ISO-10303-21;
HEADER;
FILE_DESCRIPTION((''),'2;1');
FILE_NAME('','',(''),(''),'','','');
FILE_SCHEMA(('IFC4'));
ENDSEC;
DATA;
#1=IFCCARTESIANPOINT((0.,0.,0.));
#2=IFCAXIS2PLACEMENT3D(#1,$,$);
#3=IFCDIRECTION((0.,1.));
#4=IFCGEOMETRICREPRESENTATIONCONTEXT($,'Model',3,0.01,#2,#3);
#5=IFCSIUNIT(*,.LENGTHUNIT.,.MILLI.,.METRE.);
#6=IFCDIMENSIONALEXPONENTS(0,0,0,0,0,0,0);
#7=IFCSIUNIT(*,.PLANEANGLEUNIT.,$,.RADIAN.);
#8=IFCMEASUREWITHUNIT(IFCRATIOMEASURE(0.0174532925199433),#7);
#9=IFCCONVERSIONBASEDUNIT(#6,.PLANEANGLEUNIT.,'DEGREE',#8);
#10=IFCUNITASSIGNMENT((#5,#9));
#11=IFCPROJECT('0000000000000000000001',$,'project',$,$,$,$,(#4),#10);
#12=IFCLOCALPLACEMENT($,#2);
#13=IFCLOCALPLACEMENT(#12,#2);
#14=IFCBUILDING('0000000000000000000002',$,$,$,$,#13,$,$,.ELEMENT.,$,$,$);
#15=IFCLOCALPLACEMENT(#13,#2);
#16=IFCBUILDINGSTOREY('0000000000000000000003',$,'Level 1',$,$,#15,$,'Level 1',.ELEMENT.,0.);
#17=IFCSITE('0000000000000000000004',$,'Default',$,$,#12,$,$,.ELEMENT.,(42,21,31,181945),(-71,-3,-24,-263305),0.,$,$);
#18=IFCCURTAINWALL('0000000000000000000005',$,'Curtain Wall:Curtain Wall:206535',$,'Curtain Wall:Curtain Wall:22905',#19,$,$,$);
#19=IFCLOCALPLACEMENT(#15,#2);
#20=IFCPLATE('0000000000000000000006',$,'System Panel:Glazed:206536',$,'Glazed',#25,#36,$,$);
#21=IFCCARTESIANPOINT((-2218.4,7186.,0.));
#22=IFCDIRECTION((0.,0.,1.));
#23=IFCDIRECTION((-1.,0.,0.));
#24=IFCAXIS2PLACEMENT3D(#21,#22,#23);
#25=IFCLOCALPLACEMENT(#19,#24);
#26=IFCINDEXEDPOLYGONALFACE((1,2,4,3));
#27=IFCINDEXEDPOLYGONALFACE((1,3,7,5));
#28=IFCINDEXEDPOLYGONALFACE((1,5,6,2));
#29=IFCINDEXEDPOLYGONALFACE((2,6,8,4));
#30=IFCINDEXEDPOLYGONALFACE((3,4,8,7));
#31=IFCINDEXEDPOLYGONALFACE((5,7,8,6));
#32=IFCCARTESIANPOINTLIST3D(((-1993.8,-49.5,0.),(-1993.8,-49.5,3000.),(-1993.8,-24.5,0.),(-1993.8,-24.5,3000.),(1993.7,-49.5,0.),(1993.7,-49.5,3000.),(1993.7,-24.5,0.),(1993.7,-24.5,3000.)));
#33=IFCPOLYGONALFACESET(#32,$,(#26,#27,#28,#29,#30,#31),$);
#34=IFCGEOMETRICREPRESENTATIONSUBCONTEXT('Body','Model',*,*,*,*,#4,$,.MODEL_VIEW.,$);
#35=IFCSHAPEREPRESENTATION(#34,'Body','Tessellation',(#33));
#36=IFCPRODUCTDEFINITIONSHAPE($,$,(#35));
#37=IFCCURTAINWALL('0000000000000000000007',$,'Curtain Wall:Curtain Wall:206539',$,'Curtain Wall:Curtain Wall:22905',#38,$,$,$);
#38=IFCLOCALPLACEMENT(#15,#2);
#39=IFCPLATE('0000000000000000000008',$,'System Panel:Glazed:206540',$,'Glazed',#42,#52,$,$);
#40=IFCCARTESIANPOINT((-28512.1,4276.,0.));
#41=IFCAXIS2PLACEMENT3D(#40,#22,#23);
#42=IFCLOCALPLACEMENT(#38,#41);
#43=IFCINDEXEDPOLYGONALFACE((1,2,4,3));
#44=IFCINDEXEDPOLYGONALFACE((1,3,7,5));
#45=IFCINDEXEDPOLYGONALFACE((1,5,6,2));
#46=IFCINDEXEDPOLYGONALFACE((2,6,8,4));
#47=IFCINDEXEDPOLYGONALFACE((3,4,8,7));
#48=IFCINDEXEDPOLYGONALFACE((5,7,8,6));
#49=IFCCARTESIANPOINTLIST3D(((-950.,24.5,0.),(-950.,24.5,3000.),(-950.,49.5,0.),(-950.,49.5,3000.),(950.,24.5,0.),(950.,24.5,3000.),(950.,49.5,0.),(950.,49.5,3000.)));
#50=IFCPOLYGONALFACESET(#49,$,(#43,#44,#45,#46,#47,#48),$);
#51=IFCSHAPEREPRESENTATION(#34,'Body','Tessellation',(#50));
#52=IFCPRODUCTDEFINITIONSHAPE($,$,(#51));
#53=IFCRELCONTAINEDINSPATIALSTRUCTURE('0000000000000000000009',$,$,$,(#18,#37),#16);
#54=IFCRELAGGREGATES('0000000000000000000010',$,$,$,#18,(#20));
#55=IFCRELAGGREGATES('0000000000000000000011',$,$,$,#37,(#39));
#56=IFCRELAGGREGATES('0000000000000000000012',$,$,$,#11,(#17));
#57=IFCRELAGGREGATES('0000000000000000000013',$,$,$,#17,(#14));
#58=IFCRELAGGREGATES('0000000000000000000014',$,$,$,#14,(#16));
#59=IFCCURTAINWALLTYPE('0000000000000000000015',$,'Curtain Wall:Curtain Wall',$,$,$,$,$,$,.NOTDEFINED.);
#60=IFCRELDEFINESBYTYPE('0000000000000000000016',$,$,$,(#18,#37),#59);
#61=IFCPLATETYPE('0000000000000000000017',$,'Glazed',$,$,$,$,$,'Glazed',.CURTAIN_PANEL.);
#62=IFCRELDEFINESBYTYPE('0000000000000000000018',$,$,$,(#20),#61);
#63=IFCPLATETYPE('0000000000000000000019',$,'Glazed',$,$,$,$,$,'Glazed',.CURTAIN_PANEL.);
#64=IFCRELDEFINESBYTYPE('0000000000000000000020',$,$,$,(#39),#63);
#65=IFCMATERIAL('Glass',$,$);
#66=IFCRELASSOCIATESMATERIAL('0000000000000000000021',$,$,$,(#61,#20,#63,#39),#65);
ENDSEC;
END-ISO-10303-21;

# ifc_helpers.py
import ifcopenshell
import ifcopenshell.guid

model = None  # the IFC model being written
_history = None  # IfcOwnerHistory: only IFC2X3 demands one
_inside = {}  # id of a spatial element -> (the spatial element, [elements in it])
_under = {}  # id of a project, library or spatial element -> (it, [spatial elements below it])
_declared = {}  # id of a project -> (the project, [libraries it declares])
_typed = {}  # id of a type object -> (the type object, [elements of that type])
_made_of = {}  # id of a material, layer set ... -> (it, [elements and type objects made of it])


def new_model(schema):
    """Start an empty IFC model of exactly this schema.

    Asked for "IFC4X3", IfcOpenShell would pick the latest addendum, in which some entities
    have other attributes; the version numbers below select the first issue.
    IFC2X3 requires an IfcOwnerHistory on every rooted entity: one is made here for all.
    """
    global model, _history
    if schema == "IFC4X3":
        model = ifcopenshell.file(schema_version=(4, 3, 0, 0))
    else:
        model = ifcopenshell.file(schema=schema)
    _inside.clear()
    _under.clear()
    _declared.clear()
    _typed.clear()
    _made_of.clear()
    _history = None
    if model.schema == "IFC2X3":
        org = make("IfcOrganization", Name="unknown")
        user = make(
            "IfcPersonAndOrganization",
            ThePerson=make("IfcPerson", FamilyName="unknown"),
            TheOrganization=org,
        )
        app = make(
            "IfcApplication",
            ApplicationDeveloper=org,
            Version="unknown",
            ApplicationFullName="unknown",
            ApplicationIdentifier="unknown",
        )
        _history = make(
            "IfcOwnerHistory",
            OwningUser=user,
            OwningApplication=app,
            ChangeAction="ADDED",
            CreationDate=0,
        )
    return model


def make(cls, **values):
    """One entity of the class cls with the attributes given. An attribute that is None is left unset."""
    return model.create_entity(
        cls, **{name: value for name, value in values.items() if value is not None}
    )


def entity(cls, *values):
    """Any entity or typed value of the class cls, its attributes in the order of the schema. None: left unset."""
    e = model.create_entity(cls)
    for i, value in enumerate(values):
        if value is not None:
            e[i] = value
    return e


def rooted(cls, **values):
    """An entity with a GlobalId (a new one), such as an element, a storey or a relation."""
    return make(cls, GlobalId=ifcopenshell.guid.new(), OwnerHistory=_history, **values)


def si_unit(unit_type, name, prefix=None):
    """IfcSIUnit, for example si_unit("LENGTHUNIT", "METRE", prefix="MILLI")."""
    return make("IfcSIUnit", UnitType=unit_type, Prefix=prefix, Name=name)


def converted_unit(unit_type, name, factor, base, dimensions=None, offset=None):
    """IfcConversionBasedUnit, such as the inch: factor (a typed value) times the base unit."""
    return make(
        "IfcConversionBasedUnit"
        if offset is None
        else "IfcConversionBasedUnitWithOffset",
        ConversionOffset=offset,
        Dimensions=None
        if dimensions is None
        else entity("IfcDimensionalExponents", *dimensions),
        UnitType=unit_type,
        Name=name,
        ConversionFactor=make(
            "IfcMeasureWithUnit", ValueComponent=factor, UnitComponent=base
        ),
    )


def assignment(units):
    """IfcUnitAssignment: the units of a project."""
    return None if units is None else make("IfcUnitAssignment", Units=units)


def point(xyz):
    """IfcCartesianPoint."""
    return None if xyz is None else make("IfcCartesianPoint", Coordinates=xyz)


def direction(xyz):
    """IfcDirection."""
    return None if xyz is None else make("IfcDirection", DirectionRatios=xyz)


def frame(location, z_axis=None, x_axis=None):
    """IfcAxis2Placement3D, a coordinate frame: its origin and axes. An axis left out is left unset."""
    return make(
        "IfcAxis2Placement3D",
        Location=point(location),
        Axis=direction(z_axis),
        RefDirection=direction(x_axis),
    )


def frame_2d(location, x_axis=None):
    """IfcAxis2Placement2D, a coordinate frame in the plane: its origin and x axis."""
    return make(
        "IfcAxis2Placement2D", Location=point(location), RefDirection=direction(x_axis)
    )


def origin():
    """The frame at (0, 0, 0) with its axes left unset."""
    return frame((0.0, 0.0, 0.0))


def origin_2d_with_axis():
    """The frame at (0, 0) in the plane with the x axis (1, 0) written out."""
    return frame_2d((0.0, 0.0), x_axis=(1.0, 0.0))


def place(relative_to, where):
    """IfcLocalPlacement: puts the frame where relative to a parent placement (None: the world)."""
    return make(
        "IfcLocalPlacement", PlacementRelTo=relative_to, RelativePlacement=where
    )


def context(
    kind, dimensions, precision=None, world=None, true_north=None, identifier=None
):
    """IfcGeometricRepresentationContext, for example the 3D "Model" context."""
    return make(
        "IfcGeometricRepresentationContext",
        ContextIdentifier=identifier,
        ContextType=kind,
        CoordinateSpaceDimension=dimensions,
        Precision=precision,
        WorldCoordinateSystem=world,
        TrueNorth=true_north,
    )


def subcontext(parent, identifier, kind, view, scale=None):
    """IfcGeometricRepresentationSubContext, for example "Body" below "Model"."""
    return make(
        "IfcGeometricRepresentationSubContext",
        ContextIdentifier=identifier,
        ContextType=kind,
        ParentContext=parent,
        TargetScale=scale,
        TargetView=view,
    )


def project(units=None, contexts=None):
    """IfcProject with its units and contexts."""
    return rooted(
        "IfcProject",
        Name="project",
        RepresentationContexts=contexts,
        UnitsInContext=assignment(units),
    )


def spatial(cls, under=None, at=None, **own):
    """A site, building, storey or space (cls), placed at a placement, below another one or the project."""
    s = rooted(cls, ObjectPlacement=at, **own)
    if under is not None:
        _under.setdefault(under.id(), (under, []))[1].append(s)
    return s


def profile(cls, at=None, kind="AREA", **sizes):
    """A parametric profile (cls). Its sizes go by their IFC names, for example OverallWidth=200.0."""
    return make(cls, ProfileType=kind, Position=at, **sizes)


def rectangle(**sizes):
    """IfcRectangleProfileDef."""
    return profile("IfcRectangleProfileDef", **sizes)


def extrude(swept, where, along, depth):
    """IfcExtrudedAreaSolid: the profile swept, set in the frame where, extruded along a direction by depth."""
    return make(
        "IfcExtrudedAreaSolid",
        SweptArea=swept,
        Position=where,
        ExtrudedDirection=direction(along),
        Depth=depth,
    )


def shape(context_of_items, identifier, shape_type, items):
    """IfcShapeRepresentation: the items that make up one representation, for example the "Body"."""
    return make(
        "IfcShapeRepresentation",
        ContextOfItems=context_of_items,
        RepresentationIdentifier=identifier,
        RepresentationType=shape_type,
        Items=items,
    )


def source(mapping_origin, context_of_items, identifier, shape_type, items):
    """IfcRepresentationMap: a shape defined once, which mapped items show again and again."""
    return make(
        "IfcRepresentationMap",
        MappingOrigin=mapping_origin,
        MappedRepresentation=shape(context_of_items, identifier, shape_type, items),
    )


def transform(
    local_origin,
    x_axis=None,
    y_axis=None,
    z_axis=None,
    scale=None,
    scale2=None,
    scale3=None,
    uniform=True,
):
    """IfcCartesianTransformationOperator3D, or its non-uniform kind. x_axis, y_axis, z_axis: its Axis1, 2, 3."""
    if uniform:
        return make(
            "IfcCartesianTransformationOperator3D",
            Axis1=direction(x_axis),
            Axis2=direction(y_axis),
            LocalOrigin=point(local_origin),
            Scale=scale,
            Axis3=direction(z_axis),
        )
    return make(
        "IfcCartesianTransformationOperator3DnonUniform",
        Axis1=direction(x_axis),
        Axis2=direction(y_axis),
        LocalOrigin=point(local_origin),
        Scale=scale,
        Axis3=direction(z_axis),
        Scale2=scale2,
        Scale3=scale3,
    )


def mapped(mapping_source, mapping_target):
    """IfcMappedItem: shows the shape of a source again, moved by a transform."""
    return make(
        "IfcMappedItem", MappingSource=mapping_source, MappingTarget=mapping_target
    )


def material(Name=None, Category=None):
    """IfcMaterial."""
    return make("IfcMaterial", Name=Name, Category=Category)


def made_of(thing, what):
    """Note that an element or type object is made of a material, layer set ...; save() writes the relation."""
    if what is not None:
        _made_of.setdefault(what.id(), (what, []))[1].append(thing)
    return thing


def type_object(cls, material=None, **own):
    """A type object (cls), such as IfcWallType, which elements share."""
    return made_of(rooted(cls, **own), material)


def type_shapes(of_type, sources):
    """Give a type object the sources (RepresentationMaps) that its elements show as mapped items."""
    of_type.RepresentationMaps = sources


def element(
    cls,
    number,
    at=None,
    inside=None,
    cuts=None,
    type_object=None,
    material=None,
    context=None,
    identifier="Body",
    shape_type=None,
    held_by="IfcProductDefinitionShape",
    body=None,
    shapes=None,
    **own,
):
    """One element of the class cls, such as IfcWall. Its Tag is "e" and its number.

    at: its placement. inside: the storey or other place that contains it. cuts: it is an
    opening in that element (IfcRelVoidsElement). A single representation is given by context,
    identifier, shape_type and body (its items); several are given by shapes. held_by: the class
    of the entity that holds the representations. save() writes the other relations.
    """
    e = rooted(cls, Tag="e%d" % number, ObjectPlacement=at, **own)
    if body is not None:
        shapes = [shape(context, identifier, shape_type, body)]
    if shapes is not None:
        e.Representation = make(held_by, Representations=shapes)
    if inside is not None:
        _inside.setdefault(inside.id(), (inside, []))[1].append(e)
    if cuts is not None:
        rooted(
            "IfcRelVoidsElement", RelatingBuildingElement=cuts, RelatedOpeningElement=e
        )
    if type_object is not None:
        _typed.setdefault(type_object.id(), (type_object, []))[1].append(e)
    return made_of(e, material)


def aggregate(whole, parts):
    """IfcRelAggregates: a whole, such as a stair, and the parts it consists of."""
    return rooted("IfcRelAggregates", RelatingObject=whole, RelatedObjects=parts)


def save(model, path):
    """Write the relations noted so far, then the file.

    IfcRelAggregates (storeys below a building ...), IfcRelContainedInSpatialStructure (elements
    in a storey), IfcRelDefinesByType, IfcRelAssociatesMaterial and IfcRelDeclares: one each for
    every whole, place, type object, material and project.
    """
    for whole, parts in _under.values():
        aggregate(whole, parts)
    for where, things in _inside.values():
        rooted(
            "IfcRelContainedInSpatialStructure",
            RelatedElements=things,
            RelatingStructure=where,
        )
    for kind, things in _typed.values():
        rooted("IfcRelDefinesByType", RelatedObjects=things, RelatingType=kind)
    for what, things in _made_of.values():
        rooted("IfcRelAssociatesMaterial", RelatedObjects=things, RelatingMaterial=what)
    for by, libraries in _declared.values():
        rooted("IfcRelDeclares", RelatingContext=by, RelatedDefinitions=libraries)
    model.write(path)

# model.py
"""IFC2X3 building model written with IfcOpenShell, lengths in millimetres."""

from ifc_helpers import new_model, entity, si_unit, converted_unit, direction, frame, frame_2d, origin, origin_2d_with_axis, place, context, subcontext, project, spatial, rectangle, extrude, source, transform, mapped, material, type_object, type_shapes, element, aggregate, save


model = new_model("IFC2X3")

# Units and contexts
model_context = context("Model", 3, precision=0.01, world=origin(), true_north=direction((0.0, 1.0)))
body_context = subcontext(model_context, "Body", "Model", "MODEL_VIEW")
ifc_project = project(units=[si_unit("LENGTHUNIT", "METRE", prefix="MILLI"), converted_unit("PLANEANGLEUNIT", "DEGREE", entity("IfcRatioMeasure", 0.0174532925199433), si_unit("PLANEANGLEUNIT", "RADIAN"), dimensions=[0, 0, 0, 0, 0, 0, 0])], contexts=[model_context])

# Site, building, storey
site_placement = place(None, origin())
site = spatial("IfcSite", under=ifc_project, at=site_placement, Name="Default", CompositionType="ELEMENT", RefLatitude=(42, 21, 31, 181945), RefLongitude=(-71, -3, -24, -263305), RefElevation=0.0)
building_placement = place(site_placement, origin())
building = spatial("IfcBuilding", under=site, at=building_placement, CompositionType="ELEMENT")
storey_placement = place(building_placement, origin())
storey = spatial("IfcBuildingStorey", under=building, at=storey_placement, Name="Level 1", LongName="Level 1", CompositionType="ELEMENT", Elevation=0.0)

# Curtain walls, plates
curtain_wall_type = type_object("IfcCurtainWallType", Name="Curtain Wall:Curtain Wall", PredefinedType="NOTDEFINED")
curtain_wall_1_placement = place(storey_placement, origin())
curtain_wall_1 = element("IfcCurtainWall", 1, at=curtain_wall_1_placement, inside=storey, type_object=curtain_wall_type, Name="Curtain Wall:Curtain Wall:206535", ObjectType="Curtain Wall:Curtain Wall:22905")
ifc_material_1 = material(Name="Glass")
plate_type_1 = type_object("IfcPlateType", Name="Glazed", ElementType="Glazed", PredefinedType="CURTAIN_PANEL", material=ifc_material_1)
shared_shape_1 = source(origin(), body_context, "Body", "SweptSolid", [
    extrude(rectangle(XDim=25.0, YDim=3987.5, at=frame_2d((0.0, 0.0), x_axis=(1.0, 0.0))), frame((0.0, -37.0, 0.0), z_axis=(0.0, 0.0, 1.0), x_axis=(0.0, 1.0, 0.0)), (0.0, 0.0, 1.0), 3000.0),
])
type_shapes(plate_type_1, [shared_shape_1])
plate_1_placement = place(curtain_wall_1_placement, frame((-2218.4, 7186.0, 0.0), z_axis=(0.0, 0.0, 1.0), x_axis=(-1.0, 0.0, 0.0)))
plate_1 = element("IfcPlate", 2, at=plate_1_placement, type_object=plate_type_1, material=ifc_material_1, Name="System Panel:Glazed:206536", ObjectType="Glazed", context=body_context, shape_type="MappedRepresentation", body=[
    mapped(shared_shape_1, transform((0.0, 0.0, 0.0), scale=1.0)),
])
aggregate(curtain_wall_1, [plate_1])
curtain_wall_2_placement = place(storey_placement, origin())
curtain_wall_2 = element("IfcCurtainWall", 3, at=curtain_wall_2_placement, inside=storey, type_object=curtain_wall_type, Name="Curtain Wall:Curtain Wall:206539", ObjectType="Curtain Wall:Curtain Wall:22905")
plate_type_2 = type_object("IfcPlateType", Name="Glazed", ElementType="Glazed", PredefinedType="CURTAIN_PANEL", material=ifc_material_1)
shared_shape_2 = source(origin(), body_context, "Body", "SweptSolid", [
    extrude(rectangle(XDim=25.0, YDim=1900.0, at=origin_2d_with_axis()), frame((0.0, 37.0, 0.0), z_axis=(0.0, 0.0, 1.0), x_axis=(0.0, 1.0, 0.0)), (0.0, 0.0, 1.0), 3000.0),
])
type_shapes(plate_type_2, [shared_shape_2])
plate_2_placement = place(curtain_wall_2_placement, frame((-28512.1, 4276.0, 0.0), z_axis=(0.0, 0.0, 1.0), x_axis=(-1.0, 0.0, 0.0)))
plate_2 = element("IfcPlate", 4, at=plate_2_placement, type_object=plate_type_2, material=ifc_material_1, Name="System Panel:Glazed:206540", ObjectType="Glazed", context=body_context, shape_type="MappedRepresentation", body=[
    mapped(shared_shape_2, transform((0.0, 0.0, 0.0), scale=1.0)),
])
aggregate(curtain_wall_2, [plate_2])

save(model, "model.ifc")
